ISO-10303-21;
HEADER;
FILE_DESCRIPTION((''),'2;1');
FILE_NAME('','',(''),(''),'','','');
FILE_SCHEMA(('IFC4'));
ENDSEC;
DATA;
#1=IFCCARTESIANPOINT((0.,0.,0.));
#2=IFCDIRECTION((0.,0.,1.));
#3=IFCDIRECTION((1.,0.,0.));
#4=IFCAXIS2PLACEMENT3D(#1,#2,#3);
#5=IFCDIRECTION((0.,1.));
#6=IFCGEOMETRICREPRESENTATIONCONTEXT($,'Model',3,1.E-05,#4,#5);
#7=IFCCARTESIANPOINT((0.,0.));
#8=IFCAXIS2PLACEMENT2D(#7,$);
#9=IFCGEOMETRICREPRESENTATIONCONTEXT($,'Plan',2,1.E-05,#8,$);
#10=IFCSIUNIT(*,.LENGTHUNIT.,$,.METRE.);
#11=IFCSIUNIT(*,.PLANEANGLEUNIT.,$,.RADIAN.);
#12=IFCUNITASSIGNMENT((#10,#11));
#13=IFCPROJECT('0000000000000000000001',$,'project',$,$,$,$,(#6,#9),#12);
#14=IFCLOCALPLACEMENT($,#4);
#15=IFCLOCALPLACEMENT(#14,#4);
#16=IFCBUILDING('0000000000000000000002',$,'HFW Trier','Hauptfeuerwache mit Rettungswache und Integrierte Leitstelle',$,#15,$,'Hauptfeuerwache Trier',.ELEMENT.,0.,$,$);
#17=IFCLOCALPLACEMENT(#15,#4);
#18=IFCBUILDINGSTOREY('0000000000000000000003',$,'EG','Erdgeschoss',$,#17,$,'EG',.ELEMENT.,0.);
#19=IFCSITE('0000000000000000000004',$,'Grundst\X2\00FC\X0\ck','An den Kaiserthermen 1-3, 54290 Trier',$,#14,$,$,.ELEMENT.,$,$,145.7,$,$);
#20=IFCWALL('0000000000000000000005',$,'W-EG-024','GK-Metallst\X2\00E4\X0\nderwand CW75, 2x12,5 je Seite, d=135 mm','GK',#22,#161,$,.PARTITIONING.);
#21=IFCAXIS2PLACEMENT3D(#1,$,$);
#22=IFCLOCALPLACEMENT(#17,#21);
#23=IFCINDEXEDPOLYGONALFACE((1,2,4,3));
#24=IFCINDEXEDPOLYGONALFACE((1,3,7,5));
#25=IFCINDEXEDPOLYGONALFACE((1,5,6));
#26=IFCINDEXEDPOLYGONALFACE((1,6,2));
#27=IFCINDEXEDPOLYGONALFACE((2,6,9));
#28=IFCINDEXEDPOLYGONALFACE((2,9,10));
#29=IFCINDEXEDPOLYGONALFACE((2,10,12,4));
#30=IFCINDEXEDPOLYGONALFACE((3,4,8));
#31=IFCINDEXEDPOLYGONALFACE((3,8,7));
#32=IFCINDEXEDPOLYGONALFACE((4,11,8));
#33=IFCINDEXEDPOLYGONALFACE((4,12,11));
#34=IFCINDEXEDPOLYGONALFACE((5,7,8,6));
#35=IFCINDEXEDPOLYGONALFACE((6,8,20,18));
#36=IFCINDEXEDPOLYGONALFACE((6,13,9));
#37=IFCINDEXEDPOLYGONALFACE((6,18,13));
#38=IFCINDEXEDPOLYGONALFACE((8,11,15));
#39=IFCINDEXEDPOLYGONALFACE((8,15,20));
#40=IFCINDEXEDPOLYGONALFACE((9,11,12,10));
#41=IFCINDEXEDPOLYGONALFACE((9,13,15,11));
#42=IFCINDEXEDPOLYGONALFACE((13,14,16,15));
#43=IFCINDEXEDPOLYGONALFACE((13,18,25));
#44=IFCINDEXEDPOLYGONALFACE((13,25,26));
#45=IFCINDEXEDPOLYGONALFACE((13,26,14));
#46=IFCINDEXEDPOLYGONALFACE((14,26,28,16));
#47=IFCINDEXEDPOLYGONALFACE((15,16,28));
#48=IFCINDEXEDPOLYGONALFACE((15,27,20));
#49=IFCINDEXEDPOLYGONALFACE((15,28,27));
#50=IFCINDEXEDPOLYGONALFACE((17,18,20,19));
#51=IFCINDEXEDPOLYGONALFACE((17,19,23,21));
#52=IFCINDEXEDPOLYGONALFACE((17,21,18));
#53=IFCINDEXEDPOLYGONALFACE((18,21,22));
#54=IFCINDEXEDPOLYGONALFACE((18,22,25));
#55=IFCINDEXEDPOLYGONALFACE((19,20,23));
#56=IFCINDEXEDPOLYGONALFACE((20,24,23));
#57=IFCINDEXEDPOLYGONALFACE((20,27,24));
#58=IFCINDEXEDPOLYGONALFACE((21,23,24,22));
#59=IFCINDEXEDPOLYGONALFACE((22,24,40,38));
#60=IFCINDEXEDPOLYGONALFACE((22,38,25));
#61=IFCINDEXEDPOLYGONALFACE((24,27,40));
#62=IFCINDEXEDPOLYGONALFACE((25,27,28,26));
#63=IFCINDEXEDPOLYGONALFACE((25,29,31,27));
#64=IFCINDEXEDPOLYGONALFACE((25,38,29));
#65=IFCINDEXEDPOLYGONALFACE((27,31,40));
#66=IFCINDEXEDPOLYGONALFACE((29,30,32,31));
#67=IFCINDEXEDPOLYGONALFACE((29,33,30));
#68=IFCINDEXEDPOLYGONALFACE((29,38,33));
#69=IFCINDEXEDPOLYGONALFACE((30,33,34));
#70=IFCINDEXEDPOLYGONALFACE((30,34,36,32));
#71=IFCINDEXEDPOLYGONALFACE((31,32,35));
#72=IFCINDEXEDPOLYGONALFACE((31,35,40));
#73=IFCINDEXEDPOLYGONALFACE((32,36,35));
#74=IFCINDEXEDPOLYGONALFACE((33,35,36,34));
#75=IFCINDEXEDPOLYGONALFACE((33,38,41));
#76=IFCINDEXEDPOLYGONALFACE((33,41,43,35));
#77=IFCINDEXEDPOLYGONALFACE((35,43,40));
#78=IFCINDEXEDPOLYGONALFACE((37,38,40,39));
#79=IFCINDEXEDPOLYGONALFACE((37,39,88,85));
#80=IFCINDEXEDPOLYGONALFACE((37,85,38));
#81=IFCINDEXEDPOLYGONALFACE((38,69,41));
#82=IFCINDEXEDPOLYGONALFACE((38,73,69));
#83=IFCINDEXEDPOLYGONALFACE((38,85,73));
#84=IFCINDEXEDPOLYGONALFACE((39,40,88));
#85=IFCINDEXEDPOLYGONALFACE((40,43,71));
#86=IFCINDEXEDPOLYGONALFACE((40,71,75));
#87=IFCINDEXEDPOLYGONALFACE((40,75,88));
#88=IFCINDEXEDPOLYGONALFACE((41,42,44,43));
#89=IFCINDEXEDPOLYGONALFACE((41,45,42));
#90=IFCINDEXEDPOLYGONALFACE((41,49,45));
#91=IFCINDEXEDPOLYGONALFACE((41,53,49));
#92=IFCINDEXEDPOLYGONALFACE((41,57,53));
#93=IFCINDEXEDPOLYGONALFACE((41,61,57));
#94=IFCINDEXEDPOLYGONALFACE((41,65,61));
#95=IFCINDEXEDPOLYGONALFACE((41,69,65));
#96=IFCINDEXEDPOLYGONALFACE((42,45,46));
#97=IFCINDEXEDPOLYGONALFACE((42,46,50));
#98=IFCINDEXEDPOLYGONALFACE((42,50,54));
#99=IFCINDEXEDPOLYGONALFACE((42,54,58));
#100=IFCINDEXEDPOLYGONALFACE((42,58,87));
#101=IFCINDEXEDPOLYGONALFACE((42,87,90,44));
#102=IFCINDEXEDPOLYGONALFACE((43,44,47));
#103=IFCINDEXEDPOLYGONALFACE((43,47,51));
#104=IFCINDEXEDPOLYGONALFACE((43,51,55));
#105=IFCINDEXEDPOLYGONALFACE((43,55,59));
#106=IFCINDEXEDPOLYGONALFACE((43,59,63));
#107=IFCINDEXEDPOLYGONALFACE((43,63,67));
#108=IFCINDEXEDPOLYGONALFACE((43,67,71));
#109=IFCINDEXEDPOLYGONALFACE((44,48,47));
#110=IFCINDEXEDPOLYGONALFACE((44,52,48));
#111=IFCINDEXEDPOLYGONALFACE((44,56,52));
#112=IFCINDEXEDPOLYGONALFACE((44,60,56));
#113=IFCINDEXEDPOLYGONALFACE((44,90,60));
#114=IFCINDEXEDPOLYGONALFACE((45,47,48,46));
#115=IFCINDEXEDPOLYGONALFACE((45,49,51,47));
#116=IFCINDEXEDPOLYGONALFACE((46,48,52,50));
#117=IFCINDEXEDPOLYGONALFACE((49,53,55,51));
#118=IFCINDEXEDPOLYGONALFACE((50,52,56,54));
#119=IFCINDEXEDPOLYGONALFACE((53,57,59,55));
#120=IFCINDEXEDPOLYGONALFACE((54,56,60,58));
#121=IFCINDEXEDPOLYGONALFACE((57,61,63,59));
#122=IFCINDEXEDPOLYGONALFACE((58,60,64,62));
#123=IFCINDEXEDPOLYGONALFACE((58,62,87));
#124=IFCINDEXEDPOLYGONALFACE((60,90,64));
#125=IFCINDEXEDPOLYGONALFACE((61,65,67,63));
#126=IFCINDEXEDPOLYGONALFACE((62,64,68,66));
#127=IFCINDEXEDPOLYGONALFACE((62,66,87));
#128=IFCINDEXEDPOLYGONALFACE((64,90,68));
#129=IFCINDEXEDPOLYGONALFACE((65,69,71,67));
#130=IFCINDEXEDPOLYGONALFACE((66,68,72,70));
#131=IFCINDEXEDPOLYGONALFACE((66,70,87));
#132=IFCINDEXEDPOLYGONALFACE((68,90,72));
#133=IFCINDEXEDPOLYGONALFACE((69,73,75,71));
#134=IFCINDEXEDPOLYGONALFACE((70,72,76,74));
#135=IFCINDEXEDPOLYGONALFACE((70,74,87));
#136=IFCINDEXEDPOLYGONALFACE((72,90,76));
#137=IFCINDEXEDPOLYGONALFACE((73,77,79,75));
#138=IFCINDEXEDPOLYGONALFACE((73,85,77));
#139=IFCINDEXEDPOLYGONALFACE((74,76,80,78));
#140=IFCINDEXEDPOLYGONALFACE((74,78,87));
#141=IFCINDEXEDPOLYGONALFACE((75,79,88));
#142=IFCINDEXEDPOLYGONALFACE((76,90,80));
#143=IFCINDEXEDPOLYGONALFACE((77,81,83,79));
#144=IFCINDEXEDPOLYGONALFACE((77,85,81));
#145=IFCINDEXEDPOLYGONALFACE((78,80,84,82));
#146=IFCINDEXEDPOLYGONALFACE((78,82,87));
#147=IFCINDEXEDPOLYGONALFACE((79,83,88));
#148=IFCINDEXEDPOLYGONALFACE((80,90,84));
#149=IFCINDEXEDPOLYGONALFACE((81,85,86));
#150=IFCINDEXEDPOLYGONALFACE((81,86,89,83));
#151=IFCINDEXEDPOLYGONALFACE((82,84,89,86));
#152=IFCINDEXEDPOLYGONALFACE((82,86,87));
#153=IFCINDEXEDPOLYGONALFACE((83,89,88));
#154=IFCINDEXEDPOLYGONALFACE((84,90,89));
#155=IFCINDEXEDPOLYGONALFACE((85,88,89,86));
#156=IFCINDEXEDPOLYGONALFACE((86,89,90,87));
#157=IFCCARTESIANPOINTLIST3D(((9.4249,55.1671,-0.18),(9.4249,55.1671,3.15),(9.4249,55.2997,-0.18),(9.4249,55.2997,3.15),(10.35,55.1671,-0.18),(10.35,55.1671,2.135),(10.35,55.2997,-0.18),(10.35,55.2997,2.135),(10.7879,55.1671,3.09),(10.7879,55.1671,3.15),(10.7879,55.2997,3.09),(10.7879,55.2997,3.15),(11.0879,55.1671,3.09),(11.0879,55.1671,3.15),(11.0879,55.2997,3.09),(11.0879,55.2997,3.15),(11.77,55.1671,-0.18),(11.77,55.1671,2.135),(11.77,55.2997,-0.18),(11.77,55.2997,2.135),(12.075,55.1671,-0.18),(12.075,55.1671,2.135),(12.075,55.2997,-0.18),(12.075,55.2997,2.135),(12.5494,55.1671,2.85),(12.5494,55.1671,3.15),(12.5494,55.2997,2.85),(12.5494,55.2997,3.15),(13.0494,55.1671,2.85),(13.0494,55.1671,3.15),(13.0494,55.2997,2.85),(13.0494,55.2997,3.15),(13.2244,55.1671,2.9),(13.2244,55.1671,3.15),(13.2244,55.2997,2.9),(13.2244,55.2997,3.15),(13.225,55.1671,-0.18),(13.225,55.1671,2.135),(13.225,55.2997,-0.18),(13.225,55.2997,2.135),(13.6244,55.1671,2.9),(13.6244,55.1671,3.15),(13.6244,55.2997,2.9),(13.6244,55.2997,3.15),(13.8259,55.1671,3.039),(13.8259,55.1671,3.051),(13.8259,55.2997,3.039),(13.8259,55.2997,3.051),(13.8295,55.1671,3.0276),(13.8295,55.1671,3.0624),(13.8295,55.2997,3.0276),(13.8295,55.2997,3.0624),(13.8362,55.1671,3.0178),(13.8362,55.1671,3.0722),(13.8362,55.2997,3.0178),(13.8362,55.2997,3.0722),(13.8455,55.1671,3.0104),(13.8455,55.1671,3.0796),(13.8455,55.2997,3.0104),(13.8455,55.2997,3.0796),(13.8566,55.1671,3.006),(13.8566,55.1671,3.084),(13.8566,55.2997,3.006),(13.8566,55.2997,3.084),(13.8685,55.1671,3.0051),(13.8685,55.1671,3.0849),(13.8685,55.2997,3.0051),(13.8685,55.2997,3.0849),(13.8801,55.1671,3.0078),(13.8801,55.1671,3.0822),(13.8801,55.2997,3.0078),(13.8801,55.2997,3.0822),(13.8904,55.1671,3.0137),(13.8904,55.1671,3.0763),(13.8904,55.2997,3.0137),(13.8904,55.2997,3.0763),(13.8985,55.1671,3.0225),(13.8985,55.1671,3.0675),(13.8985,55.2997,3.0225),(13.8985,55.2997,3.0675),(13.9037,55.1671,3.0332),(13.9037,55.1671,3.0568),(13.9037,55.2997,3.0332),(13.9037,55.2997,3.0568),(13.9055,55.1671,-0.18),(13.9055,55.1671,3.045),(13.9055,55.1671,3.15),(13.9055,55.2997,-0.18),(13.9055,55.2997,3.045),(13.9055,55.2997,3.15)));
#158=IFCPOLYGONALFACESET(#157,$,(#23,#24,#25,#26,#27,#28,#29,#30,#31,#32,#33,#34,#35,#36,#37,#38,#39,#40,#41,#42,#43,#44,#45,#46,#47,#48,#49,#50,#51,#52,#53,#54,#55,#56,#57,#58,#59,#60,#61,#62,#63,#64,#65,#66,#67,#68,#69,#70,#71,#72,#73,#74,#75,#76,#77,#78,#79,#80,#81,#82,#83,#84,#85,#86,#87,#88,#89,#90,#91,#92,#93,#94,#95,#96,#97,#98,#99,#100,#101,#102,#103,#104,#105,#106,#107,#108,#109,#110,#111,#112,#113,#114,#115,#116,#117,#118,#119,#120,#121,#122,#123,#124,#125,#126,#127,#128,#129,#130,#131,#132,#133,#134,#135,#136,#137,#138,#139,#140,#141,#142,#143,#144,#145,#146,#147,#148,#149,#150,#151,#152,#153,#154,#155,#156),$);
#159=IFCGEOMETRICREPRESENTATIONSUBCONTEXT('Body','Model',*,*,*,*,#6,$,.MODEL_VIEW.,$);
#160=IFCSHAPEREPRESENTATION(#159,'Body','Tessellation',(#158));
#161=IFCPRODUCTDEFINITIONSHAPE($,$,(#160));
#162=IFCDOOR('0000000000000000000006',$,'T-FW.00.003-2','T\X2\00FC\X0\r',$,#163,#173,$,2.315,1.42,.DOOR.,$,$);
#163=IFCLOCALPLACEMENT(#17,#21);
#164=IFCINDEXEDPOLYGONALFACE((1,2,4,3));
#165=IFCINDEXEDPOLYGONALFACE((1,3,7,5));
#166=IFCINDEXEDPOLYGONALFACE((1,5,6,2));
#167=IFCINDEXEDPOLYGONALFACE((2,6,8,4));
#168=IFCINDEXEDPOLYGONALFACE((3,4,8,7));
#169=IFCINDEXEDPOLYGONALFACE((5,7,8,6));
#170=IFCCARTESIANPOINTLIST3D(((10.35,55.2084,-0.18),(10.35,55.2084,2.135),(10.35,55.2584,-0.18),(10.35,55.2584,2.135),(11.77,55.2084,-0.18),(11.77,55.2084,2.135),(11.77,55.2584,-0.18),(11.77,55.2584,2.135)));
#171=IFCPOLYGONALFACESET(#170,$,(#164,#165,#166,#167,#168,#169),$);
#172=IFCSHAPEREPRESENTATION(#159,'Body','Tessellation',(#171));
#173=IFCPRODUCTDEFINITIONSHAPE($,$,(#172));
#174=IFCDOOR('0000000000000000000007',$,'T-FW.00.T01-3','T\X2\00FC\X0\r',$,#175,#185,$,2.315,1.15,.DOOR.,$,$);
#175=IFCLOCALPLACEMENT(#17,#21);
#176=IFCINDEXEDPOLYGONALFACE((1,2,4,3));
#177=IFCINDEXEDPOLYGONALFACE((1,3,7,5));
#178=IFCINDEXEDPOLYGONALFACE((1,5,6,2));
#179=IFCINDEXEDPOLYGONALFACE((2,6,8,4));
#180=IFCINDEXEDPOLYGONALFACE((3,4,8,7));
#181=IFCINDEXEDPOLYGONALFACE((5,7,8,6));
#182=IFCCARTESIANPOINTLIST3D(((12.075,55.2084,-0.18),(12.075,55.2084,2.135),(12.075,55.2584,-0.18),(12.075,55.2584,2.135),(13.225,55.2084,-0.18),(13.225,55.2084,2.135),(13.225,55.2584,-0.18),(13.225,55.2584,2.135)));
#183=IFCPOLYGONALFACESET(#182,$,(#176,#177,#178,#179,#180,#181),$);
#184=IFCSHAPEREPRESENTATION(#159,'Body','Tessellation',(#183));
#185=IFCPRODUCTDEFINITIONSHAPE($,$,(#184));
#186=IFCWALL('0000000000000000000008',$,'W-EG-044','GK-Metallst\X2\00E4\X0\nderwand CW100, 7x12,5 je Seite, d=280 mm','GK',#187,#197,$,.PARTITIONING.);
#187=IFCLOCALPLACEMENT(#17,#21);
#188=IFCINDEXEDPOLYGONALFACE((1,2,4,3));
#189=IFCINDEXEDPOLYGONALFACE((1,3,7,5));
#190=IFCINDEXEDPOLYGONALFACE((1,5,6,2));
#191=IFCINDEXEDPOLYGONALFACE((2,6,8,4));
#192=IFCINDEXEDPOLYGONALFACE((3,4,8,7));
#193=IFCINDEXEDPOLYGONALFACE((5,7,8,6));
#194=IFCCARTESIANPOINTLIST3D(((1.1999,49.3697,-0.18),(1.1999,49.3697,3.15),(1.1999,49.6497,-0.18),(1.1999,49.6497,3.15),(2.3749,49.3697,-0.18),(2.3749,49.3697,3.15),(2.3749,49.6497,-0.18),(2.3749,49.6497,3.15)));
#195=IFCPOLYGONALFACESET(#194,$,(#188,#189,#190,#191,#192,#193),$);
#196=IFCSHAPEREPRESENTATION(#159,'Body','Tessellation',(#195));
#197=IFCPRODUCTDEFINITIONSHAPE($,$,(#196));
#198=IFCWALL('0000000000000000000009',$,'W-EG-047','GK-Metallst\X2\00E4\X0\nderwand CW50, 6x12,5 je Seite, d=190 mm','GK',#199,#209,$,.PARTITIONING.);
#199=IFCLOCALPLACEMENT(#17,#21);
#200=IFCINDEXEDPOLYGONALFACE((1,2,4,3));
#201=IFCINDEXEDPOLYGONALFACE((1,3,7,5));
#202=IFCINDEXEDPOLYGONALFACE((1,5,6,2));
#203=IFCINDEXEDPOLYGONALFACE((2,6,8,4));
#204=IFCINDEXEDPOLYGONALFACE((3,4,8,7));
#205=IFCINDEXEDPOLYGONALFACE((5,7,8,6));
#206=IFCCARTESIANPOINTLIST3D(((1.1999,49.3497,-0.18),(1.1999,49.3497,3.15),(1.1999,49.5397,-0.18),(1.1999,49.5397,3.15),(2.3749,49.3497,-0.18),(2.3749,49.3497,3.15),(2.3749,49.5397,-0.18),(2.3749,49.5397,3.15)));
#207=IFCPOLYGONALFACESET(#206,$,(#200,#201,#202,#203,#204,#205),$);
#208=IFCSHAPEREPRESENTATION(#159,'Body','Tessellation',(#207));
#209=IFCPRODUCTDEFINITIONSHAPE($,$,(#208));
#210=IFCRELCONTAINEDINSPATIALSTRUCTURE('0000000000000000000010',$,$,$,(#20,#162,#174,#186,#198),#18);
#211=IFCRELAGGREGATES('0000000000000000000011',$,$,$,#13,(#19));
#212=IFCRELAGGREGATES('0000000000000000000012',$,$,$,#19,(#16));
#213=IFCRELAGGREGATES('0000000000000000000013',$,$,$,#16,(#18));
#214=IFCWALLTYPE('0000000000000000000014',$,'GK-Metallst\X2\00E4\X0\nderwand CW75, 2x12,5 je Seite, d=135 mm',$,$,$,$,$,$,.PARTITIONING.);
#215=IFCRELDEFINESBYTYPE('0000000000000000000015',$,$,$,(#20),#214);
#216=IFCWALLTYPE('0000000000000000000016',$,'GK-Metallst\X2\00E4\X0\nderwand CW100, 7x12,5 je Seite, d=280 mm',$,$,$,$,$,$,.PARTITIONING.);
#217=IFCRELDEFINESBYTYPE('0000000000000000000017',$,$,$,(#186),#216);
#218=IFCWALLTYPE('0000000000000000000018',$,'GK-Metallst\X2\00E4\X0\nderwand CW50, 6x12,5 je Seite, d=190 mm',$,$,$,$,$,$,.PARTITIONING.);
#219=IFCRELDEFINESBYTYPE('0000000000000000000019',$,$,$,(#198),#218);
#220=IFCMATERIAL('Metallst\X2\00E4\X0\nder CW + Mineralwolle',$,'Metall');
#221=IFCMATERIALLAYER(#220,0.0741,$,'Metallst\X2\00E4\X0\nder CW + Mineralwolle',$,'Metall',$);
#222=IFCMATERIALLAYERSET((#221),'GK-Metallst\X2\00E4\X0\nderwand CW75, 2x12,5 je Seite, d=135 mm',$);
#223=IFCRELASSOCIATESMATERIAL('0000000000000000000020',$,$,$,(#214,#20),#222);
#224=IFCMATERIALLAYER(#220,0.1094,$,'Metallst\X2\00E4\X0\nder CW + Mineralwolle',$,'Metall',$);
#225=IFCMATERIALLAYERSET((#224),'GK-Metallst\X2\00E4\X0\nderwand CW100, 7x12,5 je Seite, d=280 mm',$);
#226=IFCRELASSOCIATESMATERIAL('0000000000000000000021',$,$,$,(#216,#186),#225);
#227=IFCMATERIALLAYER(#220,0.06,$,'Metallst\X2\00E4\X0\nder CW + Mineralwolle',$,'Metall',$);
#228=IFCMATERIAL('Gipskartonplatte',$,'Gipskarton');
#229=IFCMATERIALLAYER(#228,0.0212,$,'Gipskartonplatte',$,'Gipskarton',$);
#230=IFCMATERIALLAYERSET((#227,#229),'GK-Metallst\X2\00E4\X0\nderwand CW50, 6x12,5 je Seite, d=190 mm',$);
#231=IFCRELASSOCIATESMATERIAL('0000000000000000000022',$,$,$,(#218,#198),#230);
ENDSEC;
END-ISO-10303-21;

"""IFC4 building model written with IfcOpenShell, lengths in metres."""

from ifc_helpers import new_model, si_unit, direction, frame, frame_2d, origin_with_axes, origin_2d, place, context, subcontext, project, spatial, rectangle, circle, extrude, material, layer, layer_set, layer_usage, type_object, element, fill, save


model = new_model("IFC4")

# Units and contexts
model_context = context("Model", 3, precision=1e-05, world=origin_with_axes(), true_north=direction((0.0, 1.0)))
plan_context = context("Plan", 2, precision=1e-05, world=origin_2d())
body_context = subcontext(model_context, "Body", "Model", "MODEL_VIEW")
ifc_project = project(units=[si_unit("LENGTHUNIT", "METRE"), si_unit("PLANEANGLEUNIT", "RADIAN")], contexts=[model_context, plan_context])

# Site, building, storey
site_placement = place(None, origin_with_axes())
site = spatial("IfcSite", under=ifc_project, at=site_placement, Name="Grundstück", Description="An den Kaiserthermen 1-3, 54290 Trier", CompositionType="ELEMENT", RefElevation=145.7)
building_placement = place(site_placement, origin_with_axes())
building = spatial("IfcBuilding", under=site, at=building_placement, Name="HFW Trier", Description="Hauptfeuerwache mit Rettungswache und Integrierte Leitstelle", LongName="Hauptfeuerwache Trier", CompositionType="ELEMENT", ElevationOfRefHeight=0.0)
storey_placement = place(building_placement, origin_with_axes())
storey = spatial("IfcBuildingStorey", under=building, at=storey_placement, Name="EG", Description="Erdgeschoss", LongName="EG", CompositionType="ELEMENT", Elevation=0.0)

# Shared definitions
ifc_material_1 = material(Name="Gipskartonplatte", Category="Gipskarton")
ifc_material_2 = material(Name="Metallständer CW + Mineralwolle", Category="Metall")

# Wall, openings, doors
ifc_layer_1 = layer(ifc_material_2, 0.0741, Name="Metallständer CW + Mineralwolle", Category="Metall")
ifc_layer_set_1 = layer_set([ifc_layer_1], Name="GK-Metallständerwand CW75, 2x12,5 je Seite, d=135 mm")
ifc_layer_usage_1 = layer_usage(ifc_layer_set_1, "AXIS2", "POSITIVE", -0.0663)
wall_type_1 = type_object("IfcWallType", Name="GK-Metallständerwand CW75, 2x12,5 je Seite, d=135 mm", PredefinedType="PARTITIONING", material=ifc_layer_set_1)
wall_1_placement = place(storey_placement, frame((9.4249, 55.2334, -0.18), z_axis=(0.0, 0.0, 1.0), x_axis=(1.0, 0.0, 0.0)))
wall_1 = element("IfcWall", 1, at=wall_1_placement, inside=storey, type_object=wall_type_1, material=ifc_layer_usage_1, Name="W-EG-024", Description="GK-Metallständerwand CW75, 2x12,5 je Seite, d=135 mm", ObjectType="GK", PredefinedType="PARTITIONING", context=body_context, shape_type="SweptSolid", body=[
    extrude(rectangle(XDim=4.4806, YDim=0.1326, at=frame_2d((2.2403, 0.0))), origin_with_axes(), (0.0, 0.0, 1.0), 3.33),
])
opening_1_placement = place(wall_1_placement, frame((0.9251, 0.0, 0.0), z_axis=(0.0, 0.0, 1.0), x_axis=(1.0, 0.0, 0.0)))
opening_1 = element("IfcOpeningElement", 2, at=opening_1_placement, cuts=wall_1, PredefinedType="OPENING", context=body_context, shape_type="SweptSolid", body=[
    extrude(rectangle(XDim=1.42, YDim=0.2326, at=frame_2d((0.71, 0.0))), origin_with_axes(), (0.0, 0.0, 1.0), 2.315),
])
opening_2_placement = place(wall_1_placement, frame((2.6501, 0.0, 0.0), z_axis=(0.0, 0.0, 1.0), x_axis=(1.0, 0.0, 0.0)))
opening_2 = element("IfcOpeningElement", 3, at=opening_2_placement, cuts=wall_1, PredefinedType="OPENING", context=body_context, shape_type="SweptSolid", body=[
    extrude(rectangle(XDim=1.15, YDim=0.2326, at=frame_2d((0.575, 0.0))), origin_with_axes(), (0.0, 0.0, 1.0), 2.315),
])
opening_3_placement = place(wall_1_placement, origin_with_axes())
element("IfcOpeningElement", 4, at=opening_3_placement, cuts=wall_1, ObjectType="Wanddurchbruch", PredefinedType="OPENING", context=body_context, shape_type="SweptSolid", body=[
    extrude(circle(Radius=0.04, at=origin_2d()), frame((4.4406, -0.1163, 3.225), z_axis=(0.0, 1.0, 0.0), x_axis=(1.0, 0.0, 0.0)), (0.0, 0.0, 1.0), 0.2326),
])
opening_4_placement = place(wall_1_placement, origin_with_axes())
element("IfcOpeningElement", 5, at=opening_4_placement, cuts=wall_1, ObjectType="Wanddurchbruch", PredefinedType="OPENING", context=body_context, shape_type="SweptSolid", body=[
    extrude(rectangle(XDim=0.5, YDim=0.2326, at=frame_2d((3.3745, 0.0))), frame((0.0, 0.0, 3.03), z_axis=(0.0, 0.0, 1.0), x_axis=(1.0, 0.0, 0.0)), (0.0, 0.0, 1.0), 0.3),
])
opening_5_placement = place(wall_1_placement, origin_with_axes())
element("IfcOpeningElement", 6, at=opening_5_placement, cuts=wall_1, ObjectType="Wanddurchbruch", PredefinedType="OPENING", context=body_context, shape_type="SweptSolid", body=[
    extrude(rectangle(XDim=0.4, YDim=0.2326, at=frame_2d((3.9995, 0.0))), frame((0.0, 0.0, 3.08), z_axis=(0.0, 0.0, 1.0), x_axis=(1.0, 0.0, 0.0)), (0.0, 0.0, 1.0), 0.25),
])
opening_6_placement = place(wall_1_placement, origin_with_axes())
element("IfcOpeningElement", 7, at=opening_6_placement, cuts=wall_1, ObjectType="Wanddurchbruch", PredefinedType="OPENING", context=body_context, shape_type="SweptSolid", body=[
    extrude(rectangle(XDim=0.3, YDim=0.2326, at=frame_2d((1.513, 0.0))), frame((0.0, 0.0, 3.27), z_axis=(0.0, 0.0, 1.0), x_axis=(1.0, 0.0, 0.0)), (0.0, 0.0, 1.0), 0.06),
])
door_1_placement = place(wall_1_placement, frame((0.9251, 0.0, 0.0), z_axis=(0.0, 0.0, 1.0), x_axis=(1.0, 0.0, 0.0)))
door_1 = element("IfcDoor", 8, at=door_1_placement, inside=storey, Name="T-FW.00.003-2", Description="Tür", OverallHeight=2.315, OverallWidth=1.42, PredefinedType="DOOR", context=body_context, shape_type="SweptSolid", body=[
    extrude(rectangle(XDim=1.42, YDim=0.05, at=frame_2d((0.71, 0.0))), origin_with_axes(), (0.0, 0.0, 1.0), 2.315),
])
fill(opening_1, door_1)
door_2_placement = place(wall_1_placement, frame((2.6501, 0.0, 0.0), z_axis=(0.0, 0.0, 1.0), x_axis=(1.0, 0.0, 0.0)))
door_2 = element("IfcDoor", 9, at=door_2_placement, inside=storey, Name="T-FW.00.T01-3", Description="Tür", OverallHeight=2.315, OverallWidth=1.15, PredefinedType="DOOR", context=body_context, shape_type="SweptSolid", body=[
    extrude(rectangle(XDim=1.15, YDim=0.05, at=frame_2d((0.575, 0.0))), origin_with_axes(), (0.0, 0.0, 1.0), 2.315),
])
fill(opening_2, door_2)

# Walls
ifc_layer_2 = layer(ifc_material_2, 0.1094, Name="Metallständer CW + Mineralwolle", Category="Metall")
ifc_layer_set_2 = layer_set([ifc_layer_2], Name="GK-Metallständerwand CW100, 7x12,5 je Seite, d=280 mm")
ifc_layer_usage_2 = layer_usage(ifc_layer_set_2, "AXIS2", "POSITIVE", -0.14)
wall_type_2 = type_object("IfcWallType", Name="GK-Metallständerwand CW100, 7x12,5 je Seite, d=280 mm", PredefinedType="PARTITIONING", material=ifc_layer_set_2)
wall_2_placement = place(storey_placement, frame((1.1999, 49.5097, -0.18), z_axis=(0.0, 0.0, 1.0), x_axis=(1.0, 0.0, 0.0)))
element("IfcWall", 10, at=wall_2_placement, inside=storey, type_object=wall_type_2, material=ifc_layer_usage_2, Name="W-EG-044", Description="GK-Metallständerwand CW100, 7x12,5 je Seite, d=280 mm", ObjectType="GK", PredefinedType="PARTITIONING", context=body_context, shape_type="SweptSolid", body=[
    extrude(rectangle(XDim=1.175, YDim=0.28, at=frame_2d((0.5875, 0.0))), origin_with_axes(), (0.0, 0.0, 1.0), 3.33),
])
ifc_layer_3 = layer(ifc_material_2, 0.06, Name="Metallständer CW + Mineralwolle", Category="Metall")
ifc_layer_4 = layer(ifc_material_1, 0.0212, Name="Gipskartonplatte", Category="Gipskarton")
ifc_layer_set_3 = layer_set([ifc_layer_3, ifc_layer_4], Name="GK-Metallständerwand CW50, 6x12,5 je Seite, d=190 mm")
ifc_layer_usage_3 = layer_usage(ifc_layer_set_3, "AXIS2", "POSITIVE", -0.095)
wall_type_3 = type_object("IfcWallType", Name="GK-Metallständerwand CW50, 6x12,5 je Seite, d=190 mm", PredefinedType="PARTITIONING", material=ifc_layer_set_3)
wall_3_placement = place(storey_placement, frame((1.1999, 49.4447, -0.18), z_axis=(0.0, 0.0, 1.0), x_axis=(1.0, 0.0, 0.0)))
element("IfcWall", 11, at=wall_3_placement, inside=storey, type_object=wall_type_3, material=ifc_layer_usage_3, Name="W-EG-047", Description="GK-Metallständerwand CW50, 6x12,5 je Seite, d=190 mm", ObjectType="GK", PredefinedType="PARTITIONING", context=body_context, shape_type="SweptSolid", body=[
    extrude(rectangle(XDim=1.175, YDim=0.19, at=frame_2d((0.5875, 0.0))), origin_with_axes(), (0.0, 0.0, 1.0), 3.33),
])

save(model, "model.ifc")
